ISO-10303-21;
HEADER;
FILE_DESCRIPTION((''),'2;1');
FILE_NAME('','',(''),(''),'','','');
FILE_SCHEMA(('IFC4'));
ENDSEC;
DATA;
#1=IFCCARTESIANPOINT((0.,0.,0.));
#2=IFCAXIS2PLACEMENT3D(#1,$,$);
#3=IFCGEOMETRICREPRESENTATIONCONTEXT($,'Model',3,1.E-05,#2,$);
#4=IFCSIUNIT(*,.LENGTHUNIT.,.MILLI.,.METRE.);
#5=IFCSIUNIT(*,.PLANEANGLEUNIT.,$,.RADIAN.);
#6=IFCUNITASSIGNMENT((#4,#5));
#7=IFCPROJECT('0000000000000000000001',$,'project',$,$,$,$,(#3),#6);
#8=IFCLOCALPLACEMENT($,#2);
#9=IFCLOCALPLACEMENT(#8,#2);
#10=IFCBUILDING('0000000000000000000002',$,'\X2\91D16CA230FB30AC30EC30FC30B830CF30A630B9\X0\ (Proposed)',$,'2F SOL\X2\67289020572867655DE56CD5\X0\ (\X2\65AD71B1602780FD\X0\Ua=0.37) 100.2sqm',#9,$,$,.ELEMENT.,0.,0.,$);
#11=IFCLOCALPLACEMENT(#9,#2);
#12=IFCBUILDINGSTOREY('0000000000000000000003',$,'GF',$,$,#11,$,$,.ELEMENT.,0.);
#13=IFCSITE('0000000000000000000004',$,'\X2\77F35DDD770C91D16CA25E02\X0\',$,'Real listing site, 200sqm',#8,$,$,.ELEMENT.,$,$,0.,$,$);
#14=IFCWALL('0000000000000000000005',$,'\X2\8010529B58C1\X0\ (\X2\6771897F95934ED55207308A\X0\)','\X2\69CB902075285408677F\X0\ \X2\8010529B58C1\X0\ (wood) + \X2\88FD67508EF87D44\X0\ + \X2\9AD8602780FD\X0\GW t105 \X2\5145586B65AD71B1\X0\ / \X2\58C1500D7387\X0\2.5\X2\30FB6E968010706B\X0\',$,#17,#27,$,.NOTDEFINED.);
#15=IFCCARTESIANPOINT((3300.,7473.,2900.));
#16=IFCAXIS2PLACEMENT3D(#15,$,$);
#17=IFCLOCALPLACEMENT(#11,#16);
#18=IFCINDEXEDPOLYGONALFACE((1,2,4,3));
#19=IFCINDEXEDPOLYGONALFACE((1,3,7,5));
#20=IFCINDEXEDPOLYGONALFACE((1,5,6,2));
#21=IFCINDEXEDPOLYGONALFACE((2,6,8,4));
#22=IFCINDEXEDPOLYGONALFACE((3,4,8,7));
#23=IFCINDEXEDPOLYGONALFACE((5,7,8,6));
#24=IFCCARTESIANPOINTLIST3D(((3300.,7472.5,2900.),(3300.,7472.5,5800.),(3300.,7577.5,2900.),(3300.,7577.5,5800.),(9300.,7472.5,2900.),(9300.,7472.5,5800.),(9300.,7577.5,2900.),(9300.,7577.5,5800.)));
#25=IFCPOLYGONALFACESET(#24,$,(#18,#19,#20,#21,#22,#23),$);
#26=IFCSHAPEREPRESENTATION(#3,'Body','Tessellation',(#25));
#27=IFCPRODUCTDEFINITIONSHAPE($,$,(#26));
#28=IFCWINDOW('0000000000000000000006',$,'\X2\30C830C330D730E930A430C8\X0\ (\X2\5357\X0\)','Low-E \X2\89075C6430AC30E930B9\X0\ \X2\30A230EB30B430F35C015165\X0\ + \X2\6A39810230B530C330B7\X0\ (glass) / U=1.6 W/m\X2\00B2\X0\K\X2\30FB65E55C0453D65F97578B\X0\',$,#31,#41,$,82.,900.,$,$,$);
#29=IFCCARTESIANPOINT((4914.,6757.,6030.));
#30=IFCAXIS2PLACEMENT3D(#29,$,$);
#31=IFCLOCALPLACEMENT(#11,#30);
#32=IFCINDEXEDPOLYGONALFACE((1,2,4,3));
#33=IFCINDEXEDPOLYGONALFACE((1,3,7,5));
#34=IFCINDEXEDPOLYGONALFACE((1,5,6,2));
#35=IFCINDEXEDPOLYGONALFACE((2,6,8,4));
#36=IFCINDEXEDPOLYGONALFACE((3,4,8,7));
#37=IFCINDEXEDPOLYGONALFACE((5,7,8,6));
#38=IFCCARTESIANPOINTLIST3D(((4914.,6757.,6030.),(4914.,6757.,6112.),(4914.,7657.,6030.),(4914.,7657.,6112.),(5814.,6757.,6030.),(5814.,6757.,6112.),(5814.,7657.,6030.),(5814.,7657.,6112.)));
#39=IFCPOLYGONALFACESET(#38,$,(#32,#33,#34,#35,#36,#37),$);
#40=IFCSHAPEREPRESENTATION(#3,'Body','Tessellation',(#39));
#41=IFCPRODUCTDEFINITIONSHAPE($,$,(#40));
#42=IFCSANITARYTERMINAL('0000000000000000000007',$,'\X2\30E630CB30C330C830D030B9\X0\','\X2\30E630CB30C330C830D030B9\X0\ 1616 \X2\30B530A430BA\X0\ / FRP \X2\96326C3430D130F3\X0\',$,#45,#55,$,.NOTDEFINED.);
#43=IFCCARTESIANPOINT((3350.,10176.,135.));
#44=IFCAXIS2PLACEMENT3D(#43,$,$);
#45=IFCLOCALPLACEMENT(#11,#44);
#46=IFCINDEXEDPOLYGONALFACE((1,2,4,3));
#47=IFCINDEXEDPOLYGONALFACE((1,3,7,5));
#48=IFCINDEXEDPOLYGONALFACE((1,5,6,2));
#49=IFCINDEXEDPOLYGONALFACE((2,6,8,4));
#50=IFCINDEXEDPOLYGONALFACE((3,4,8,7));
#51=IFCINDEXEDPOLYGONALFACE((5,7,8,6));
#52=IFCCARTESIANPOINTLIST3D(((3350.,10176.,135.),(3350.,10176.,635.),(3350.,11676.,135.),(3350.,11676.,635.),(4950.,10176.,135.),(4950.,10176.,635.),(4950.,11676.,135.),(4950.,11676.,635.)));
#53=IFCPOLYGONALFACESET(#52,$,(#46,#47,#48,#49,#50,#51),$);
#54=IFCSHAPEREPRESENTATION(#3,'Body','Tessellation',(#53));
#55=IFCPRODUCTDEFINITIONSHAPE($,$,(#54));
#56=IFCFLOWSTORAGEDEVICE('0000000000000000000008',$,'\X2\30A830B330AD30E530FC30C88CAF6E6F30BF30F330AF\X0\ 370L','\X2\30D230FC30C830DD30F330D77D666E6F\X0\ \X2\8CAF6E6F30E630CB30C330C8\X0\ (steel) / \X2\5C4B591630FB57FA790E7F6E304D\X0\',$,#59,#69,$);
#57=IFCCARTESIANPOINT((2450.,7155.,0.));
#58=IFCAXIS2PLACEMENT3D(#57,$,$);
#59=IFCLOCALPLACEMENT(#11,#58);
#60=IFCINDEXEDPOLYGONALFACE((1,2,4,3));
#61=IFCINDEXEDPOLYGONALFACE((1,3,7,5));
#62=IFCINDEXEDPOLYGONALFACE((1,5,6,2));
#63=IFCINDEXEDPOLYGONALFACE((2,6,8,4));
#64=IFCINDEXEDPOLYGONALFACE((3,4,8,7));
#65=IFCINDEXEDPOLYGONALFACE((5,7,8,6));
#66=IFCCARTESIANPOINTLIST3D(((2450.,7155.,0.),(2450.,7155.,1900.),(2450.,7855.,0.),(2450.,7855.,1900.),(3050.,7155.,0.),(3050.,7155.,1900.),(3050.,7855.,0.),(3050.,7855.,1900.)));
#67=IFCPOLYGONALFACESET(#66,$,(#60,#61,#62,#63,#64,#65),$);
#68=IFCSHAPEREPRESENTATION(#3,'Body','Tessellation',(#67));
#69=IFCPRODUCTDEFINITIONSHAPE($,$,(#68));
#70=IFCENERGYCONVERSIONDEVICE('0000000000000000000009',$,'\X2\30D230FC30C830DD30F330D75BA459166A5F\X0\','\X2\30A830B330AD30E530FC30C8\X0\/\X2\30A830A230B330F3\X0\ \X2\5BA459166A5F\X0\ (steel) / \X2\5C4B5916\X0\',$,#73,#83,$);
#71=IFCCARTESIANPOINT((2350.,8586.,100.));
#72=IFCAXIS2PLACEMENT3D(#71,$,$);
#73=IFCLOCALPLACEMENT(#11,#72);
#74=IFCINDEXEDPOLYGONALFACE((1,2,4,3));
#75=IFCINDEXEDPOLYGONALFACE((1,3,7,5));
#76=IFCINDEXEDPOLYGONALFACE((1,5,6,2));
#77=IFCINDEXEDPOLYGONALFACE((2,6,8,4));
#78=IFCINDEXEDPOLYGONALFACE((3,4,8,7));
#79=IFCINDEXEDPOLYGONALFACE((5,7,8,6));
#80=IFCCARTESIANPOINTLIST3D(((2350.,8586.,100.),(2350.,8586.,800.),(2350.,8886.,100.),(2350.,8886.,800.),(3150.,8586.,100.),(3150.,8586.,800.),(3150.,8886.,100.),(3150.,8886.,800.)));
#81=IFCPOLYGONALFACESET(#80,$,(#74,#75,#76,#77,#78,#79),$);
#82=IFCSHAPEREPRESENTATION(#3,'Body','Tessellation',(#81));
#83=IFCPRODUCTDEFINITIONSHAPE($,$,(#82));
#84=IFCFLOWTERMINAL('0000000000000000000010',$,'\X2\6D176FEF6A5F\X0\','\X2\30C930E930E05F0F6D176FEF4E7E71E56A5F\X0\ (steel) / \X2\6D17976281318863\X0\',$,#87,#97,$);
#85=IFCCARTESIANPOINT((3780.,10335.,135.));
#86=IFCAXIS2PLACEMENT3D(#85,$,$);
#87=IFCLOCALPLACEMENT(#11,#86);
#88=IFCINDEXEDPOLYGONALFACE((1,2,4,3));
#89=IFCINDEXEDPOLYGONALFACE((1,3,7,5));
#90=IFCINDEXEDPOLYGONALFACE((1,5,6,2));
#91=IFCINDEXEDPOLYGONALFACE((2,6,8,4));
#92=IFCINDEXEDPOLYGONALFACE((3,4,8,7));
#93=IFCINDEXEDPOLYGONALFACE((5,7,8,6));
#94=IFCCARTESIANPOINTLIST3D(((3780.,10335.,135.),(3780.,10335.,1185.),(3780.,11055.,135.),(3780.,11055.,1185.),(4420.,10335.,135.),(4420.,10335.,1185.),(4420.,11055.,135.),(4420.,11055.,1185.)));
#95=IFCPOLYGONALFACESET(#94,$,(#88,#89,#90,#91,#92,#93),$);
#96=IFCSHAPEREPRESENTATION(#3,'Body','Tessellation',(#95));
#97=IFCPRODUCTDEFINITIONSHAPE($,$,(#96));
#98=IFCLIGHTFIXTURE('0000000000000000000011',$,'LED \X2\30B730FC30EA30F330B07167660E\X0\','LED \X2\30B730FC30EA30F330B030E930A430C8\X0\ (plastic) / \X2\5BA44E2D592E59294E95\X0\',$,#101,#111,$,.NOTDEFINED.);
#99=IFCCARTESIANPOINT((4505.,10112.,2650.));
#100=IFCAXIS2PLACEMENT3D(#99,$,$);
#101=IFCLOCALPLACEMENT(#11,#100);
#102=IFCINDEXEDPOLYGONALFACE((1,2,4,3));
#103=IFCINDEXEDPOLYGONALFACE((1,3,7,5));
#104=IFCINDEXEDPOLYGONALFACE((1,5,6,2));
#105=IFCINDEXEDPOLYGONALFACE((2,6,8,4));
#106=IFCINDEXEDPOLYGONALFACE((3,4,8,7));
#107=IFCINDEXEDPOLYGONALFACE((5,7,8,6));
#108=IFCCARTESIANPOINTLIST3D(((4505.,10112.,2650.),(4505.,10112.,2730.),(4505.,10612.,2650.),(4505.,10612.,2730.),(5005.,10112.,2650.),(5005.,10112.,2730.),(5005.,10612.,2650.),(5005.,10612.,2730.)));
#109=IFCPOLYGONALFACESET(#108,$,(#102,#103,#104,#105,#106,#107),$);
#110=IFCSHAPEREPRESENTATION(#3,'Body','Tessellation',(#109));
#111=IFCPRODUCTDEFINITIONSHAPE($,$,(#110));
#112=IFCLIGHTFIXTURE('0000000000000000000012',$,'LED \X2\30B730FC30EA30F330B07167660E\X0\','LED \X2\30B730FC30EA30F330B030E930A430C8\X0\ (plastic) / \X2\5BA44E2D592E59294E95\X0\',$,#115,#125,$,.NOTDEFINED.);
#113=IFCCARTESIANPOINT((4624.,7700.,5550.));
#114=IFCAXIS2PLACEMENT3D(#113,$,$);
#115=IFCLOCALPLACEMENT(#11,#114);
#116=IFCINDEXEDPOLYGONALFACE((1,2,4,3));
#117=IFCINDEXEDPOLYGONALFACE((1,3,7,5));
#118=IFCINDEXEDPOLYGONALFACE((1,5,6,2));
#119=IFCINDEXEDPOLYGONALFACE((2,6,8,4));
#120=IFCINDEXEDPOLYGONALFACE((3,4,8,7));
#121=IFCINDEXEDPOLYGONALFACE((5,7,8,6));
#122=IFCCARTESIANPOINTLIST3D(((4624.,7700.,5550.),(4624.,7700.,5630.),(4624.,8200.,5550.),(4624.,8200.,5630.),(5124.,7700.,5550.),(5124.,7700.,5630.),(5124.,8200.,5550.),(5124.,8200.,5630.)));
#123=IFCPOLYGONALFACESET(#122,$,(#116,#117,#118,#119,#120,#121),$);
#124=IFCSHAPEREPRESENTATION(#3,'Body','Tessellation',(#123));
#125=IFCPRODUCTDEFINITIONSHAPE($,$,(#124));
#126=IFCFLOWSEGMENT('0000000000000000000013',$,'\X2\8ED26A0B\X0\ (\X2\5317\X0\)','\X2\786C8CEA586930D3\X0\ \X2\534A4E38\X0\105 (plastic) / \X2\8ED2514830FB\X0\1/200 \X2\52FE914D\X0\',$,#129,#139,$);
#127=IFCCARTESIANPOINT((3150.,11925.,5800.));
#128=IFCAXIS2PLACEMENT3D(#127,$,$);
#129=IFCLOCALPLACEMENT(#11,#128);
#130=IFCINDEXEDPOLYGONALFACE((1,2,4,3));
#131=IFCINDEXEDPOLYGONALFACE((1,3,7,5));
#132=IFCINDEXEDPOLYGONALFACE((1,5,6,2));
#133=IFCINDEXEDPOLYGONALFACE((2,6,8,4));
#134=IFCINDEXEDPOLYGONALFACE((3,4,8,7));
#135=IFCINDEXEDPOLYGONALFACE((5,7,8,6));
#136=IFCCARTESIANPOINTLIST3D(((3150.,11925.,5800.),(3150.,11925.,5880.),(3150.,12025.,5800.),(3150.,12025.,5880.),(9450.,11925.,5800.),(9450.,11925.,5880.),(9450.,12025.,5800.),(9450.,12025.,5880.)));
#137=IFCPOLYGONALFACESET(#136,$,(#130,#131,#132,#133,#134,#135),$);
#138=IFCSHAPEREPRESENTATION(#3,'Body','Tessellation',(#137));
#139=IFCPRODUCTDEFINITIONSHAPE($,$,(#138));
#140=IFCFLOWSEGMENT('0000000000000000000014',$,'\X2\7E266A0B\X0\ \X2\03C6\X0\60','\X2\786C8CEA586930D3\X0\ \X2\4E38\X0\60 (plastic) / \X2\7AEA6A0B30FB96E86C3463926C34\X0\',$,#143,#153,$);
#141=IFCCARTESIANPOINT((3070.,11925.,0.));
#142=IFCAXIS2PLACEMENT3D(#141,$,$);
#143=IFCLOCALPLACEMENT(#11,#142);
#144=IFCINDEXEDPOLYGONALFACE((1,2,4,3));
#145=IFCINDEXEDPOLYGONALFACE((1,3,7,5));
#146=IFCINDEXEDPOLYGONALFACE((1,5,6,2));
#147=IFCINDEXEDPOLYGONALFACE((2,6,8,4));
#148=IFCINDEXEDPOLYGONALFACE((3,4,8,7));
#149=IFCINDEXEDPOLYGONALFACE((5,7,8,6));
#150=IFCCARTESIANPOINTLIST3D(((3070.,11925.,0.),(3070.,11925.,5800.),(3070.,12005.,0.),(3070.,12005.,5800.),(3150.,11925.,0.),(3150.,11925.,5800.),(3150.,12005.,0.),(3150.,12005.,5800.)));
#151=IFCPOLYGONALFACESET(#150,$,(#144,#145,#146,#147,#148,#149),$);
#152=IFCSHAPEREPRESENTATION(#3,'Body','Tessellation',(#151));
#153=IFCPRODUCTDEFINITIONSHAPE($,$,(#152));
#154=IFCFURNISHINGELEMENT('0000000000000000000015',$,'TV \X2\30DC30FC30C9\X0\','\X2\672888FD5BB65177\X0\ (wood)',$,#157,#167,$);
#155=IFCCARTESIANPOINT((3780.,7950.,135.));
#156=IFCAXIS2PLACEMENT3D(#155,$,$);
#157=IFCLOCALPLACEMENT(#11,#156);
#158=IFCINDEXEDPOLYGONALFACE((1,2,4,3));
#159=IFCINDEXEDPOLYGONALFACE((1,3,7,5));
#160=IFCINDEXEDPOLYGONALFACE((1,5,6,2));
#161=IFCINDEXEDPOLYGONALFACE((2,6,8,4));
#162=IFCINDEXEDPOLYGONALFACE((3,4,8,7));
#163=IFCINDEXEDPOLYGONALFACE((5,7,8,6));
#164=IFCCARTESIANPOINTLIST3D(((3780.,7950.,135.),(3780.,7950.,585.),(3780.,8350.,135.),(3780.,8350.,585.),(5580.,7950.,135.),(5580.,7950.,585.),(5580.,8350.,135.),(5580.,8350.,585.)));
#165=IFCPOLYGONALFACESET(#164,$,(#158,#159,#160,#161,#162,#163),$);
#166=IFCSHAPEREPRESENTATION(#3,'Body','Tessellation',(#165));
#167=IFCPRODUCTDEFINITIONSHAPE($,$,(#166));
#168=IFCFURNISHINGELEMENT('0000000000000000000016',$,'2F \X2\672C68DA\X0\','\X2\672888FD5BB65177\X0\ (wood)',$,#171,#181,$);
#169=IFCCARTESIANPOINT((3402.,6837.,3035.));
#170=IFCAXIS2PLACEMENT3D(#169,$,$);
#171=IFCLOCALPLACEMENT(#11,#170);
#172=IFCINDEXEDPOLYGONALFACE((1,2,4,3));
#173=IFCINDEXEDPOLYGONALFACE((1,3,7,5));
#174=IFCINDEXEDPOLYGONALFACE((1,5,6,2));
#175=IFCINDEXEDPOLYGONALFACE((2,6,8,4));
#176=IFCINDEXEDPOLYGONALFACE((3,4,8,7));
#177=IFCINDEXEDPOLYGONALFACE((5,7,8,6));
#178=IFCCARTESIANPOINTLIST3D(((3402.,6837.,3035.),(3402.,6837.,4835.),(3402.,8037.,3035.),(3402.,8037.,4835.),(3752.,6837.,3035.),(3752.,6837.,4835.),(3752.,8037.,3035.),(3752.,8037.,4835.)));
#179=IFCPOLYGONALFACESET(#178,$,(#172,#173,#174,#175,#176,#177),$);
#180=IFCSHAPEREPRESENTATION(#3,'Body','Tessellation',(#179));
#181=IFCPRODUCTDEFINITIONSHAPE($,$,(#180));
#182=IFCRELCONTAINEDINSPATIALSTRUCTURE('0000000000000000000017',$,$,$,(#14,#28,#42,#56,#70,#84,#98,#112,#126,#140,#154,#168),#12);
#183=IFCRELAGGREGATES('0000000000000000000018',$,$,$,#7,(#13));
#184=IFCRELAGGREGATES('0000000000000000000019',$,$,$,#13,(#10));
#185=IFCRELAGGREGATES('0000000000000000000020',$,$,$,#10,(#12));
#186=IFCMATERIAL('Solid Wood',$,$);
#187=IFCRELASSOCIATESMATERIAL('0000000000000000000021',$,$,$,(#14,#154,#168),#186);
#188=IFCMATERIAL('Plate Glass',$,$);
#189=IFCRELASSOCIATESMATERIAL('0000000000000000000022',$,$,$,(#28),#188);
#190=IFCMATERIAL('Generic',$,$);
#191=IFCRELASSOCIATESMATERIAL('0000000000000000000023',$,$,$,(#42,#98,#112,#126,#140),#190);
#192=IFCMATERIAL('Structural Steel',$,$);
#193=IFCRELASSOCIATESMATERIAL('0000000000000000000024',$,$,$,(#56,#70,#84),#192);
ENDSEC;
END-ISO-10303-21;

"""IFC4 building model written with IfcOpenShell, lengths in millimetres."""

from ifc_helpers import new_model, si_unit, frame, frame_2d, origin, place, context, project, spatial, rectangle, extrude, material, element, save


model = new_model("IFC4")

# Units and contexts
model_context = context("Model", 3, precision=1e-05, world=origin())
ifc_project = project(units=[si_unit("LENGTHUNIT", "METRE", prefix="MILLI"), si_unit("PLANEANGLEUNIT", "RADIAN")], contexts=[model_context])

# Site, building, storey
site_placement = place(None, origin())
site = spatial("IfcSite", under=ifc_project, at=site_placement, Name="石川県金沢市", ObjectType="Real listing site, 200sqm", CompositionType="ELEMENT", RefElevation=0.0)
building_placement = place(site_placement, origin())
building = spatial("IfcBuilding", under=site, at=building_placement, Name="金沢・ガレージハウス (Proposed)", ObjectType="2F SOL木造在来工法 (断熱性能Ua=0.37) 100.2sqm", CompositionType="ELEMENT", ElevationOfRefHeight=0.0, ElevationOfTerrain=0.0)
storey_placement = place(building_placement, origin())
storey = spatial("IfcBuildingStorey", under=building, at=storey_placement, Name="GF", CompositionType="ELEMENT", Elevation=0.0)

# Shared definitions
ifc_material_1 = material(Name="Solid Wood")

# Shared definitions
ifc_material_2 = material(Name="Plate Glass")

# Wall
wall_1_placement = place(storey_placement, frame((3300.0, 7473.0, 2900.0)))
element("IfcWall", 1, at=wall_1_placement, inside=storey, material=ifc_material_1, Name="耐力壁 (東西間仕切り)", Description="構造用合板 耐力壁 (wood) + 製材軸組 + 高性能GW t105 充填断熱 / 壁倍率2.5・準耐火", PredefinedType="NOTDEFINED", context=model_context, shape_type="SweptSolid", body=[
    extrude(rectangle(XDim=6000.0, YDim=105.0, at=frame_2d((3000.0, 52.0))), frame((3300.0, 7473.0, 2900.0)), (0.0, 0.0, 1.0), 2900.0),
])

# Window
window_1_placement = place(storey_placement, frame((4914.0, 6757.0, 6030.0)))
element("IfcWindow", 2, at=window_1_placement, inside=storey, material=ifc_material_2, Name="トップライト (南)", Description="Low-E 複層ガラス アルゴン封入 + 樹脂サッシ (glass) / U=1.6 W/m²K・日射取得型", OverallHeight=82.0, OverallWidth=900.0, context=model_context, shape_type="SweptSolid", body=[
    extrude(rectangle(XDim=900.0, YDim=900.0, at=frame_2d((450.0, 450.0))), frame((4914.0, 6757.0, 6030.0)), (0.0, 0.0, 1.0), 82.0),
])

# Sanitary terminal
ifc_material_3 = material(Name="Generic")
sanitary_terminal_placement = place(storey_placement, frame((3350.0, 10176.0, 135.0)))
element("IfcSanitaryTerminal", 3, at=sanitary_terminal_placement, inside=storey, material=ifc_material_3, Name="ユニットバス", Description="ユニットバス 1616 サイズ / FRP 防水パン", PredefinedType="NOTDEFINED", context=model_context, shape_type="SweptSolid", body=[
    extrude(rectangle(XDim=1600.0, YDim=1500.0, at=frame_2d((800.0, 750.0))), frame((3350.0, 10176.0, 135.0)), (0.0, 0.0, 1.0), 500.0),
])

# Flow storage device
ifc_material_4 = material(Name="Structural Steel")
flow_storage_device_placement = place(storey_placement, frame((2450.0, 7155.0, 0.0)))
element("IfcFlowStorageDevice", 4, at=flow_storage_device_placement, inside=storey, material=ifc_material_4, Name="エコキュート貯湯タンク 370L", Description="ヒートポンプ給湯 貯湯ユニット (steel) / 屋外・基礎置き", context=model_context, shape_type="SweptSolid", body=[
    extrude(rectangle(XDim=600.0, YDim=700.0, at=frame_2d((300.0, 350.0))), frame((2450.0, 7155.0, 0.0)), (0.0, 0.0, 1.0), 1900.0),
])

# Energy conversion device
energy_conversion_device_placement = place(storey_placement, frame((2350.0, 8586.0, 100.0)))
element("IfcEnergyConversionDevice", 5, at=energy_conversion_device_placement, inside=storey, material=ifc_material_4, Name="ヒートポンプ室外機", Description="エコキュート/エアコン 室外機 (steel) / 屋外", context=model_context, shape_type="SweptSolid", body=[
    extrude(rectangle(XDim=800.0, YDim=300.0, at=frame_2d((400.0, 150.0))), frame((2350.0, 8586.0, 100.0)), (0.0, 0.0, 1.0), 700.0),
])

# Flow terminal
flow_terminal_placement = place(storey_placement, frame((3780.0, 10335.0, 135.0)))
element("IfcFlowTerminal", 6, at=flow_terminal_placement, inside=storey, material=ifc_material_4, Name="洗濯機", Description="ドラム式洗濯乾燥機 (steel) / 洗面脱衣", context=model_context, shape_type="SweptSolid", body=[
    extrude(rectangle(XDim=640.0, YDim=720.0, at=frame_2d((320.0, 360.0))), frame((3780.0, 10335.0, 135.0)), (0.0, 0.0, 1.0), 1050.0),
])

# Light fixtures
light_fixture_1_placement = place(storey_placement, frame((4505.0, 10112.0, 2650.0)))
element("IfcLightFixture", 7, at=light_fixture_1_placement, inside=storey, material=ifc_material_3, Name="LED シーリング照明", Description="LED シーリングライト (plastic) / 室中央天井", PredefinedType="NOTDEFINED", context=model_context, shape_type="SweptSolid", body=[
    extrude(rectangle(XDim=500.0, YDim=500.0, at=frame_2d((250.0, 250.0))), frame((4505.0, 10112.0, 2650.0)), (0.0, 0.0, 1.0), 80.0),
])
light_fixture_2_placement = place(storey_placement, frame((4624.0, 7700.0, 5550.0)))
element("IfcLightFixture", 8, at=light_fixture_2_placement, inside=storey, material=ifc_material_3, Name="LED シーリング照明", Description="LED シーリングライト (plastic) / 室中央天井", PredefinedType="NOTDEFINED", context=model_context, shape_type="SweptSolid", body=[
    extrude(rectangle(XDim=500.0, YDim=500.0, at=frame_2d((250.0, 250.0))), frame((4624.0, 7700.0, 5550.0)), (0.0, 0.0, 1.0), 80.0),
])

# Flow segments
flow_segment_1_placement = place(storey_placement, frame((3150.0, 11925.0, 5800.0)))
element("IfcFlowSegment", 9, at=flow_segment_1_placement, inside=storey, material=ifc_material_3, Name="軒樋 (北)", Description="硬質塩ビ 半丸105 (plastic) / 軒先・1/200 勾配", context=model_context, shape_type="SweptSolid", body=[
    extrude(rectangle(XDim=6300.0, YDim=100.0, at=frame_2d((3150.0, 50.0))), frame((3150.0, 11925.0, 5800.0)), (0.0, 0.0, 1.0), 80.0),
])
flow_segment_2_placement = place(storey_placement, frame((3070.0, 11925.0, 0.0)))
element("IfcFlowSegment", 10, at=flow_segment_2_placement, inside=storey, material=ifc_material_3, Name="縦樋 φ60", Description="硬質塩ビ 丸60 (plastic) / 竪樋・雨水排水", context=model_context, shape_type="SweptSolid", body=[
    extrude(rectangle(XDim=80.0, YDim=80.0, at=frame_2d((40.0, 40.0))), frame((3070.0, 11925.0, 0.0)), (0.0, 0.0, 1.0), 5800.0),
])

# Furnishing elements
furnishing_1_placement = place(storey_placement, frame((3780.0, 7950.0, 135.0)))
element("IfcFurnishingElement", 11, at=furnishing_1_placement, inside=storey, material=ifc_material_1, Name="TV ボード", Description="木製家具 (wood)", context=model_context, shape_type="SweptSolid", body=[
    extrude(rectangle(XDim=1800.0, YDim=400.0, at=frame_2d((900.0, 200.0))), frame((3780.0, 7950.0, 135.0)), (0.0, 0.0, 1.0), 450.0),
])
furnishing_2_placement = place(storey_placement, frame((3402.0, 6837.0, 3035.0)))
element("IfcFurnishingElement", 12, at=furnishing_2_placement, inside=storey, material=ifc_material_1, Name="2F 本棚", Description="木製家具 (wood)", context=model_context, shape_type="SweptSolid", body=[
    extrude(rectangle(XDim=350.0, YDim=1200.0, at=frame_2d((175.0, 600.0))), frame((3402.0, 6837.0, 3035.0)), (0.0, 0.0, 1.0), 1800.0),
])

save(model, "model.ifc")
